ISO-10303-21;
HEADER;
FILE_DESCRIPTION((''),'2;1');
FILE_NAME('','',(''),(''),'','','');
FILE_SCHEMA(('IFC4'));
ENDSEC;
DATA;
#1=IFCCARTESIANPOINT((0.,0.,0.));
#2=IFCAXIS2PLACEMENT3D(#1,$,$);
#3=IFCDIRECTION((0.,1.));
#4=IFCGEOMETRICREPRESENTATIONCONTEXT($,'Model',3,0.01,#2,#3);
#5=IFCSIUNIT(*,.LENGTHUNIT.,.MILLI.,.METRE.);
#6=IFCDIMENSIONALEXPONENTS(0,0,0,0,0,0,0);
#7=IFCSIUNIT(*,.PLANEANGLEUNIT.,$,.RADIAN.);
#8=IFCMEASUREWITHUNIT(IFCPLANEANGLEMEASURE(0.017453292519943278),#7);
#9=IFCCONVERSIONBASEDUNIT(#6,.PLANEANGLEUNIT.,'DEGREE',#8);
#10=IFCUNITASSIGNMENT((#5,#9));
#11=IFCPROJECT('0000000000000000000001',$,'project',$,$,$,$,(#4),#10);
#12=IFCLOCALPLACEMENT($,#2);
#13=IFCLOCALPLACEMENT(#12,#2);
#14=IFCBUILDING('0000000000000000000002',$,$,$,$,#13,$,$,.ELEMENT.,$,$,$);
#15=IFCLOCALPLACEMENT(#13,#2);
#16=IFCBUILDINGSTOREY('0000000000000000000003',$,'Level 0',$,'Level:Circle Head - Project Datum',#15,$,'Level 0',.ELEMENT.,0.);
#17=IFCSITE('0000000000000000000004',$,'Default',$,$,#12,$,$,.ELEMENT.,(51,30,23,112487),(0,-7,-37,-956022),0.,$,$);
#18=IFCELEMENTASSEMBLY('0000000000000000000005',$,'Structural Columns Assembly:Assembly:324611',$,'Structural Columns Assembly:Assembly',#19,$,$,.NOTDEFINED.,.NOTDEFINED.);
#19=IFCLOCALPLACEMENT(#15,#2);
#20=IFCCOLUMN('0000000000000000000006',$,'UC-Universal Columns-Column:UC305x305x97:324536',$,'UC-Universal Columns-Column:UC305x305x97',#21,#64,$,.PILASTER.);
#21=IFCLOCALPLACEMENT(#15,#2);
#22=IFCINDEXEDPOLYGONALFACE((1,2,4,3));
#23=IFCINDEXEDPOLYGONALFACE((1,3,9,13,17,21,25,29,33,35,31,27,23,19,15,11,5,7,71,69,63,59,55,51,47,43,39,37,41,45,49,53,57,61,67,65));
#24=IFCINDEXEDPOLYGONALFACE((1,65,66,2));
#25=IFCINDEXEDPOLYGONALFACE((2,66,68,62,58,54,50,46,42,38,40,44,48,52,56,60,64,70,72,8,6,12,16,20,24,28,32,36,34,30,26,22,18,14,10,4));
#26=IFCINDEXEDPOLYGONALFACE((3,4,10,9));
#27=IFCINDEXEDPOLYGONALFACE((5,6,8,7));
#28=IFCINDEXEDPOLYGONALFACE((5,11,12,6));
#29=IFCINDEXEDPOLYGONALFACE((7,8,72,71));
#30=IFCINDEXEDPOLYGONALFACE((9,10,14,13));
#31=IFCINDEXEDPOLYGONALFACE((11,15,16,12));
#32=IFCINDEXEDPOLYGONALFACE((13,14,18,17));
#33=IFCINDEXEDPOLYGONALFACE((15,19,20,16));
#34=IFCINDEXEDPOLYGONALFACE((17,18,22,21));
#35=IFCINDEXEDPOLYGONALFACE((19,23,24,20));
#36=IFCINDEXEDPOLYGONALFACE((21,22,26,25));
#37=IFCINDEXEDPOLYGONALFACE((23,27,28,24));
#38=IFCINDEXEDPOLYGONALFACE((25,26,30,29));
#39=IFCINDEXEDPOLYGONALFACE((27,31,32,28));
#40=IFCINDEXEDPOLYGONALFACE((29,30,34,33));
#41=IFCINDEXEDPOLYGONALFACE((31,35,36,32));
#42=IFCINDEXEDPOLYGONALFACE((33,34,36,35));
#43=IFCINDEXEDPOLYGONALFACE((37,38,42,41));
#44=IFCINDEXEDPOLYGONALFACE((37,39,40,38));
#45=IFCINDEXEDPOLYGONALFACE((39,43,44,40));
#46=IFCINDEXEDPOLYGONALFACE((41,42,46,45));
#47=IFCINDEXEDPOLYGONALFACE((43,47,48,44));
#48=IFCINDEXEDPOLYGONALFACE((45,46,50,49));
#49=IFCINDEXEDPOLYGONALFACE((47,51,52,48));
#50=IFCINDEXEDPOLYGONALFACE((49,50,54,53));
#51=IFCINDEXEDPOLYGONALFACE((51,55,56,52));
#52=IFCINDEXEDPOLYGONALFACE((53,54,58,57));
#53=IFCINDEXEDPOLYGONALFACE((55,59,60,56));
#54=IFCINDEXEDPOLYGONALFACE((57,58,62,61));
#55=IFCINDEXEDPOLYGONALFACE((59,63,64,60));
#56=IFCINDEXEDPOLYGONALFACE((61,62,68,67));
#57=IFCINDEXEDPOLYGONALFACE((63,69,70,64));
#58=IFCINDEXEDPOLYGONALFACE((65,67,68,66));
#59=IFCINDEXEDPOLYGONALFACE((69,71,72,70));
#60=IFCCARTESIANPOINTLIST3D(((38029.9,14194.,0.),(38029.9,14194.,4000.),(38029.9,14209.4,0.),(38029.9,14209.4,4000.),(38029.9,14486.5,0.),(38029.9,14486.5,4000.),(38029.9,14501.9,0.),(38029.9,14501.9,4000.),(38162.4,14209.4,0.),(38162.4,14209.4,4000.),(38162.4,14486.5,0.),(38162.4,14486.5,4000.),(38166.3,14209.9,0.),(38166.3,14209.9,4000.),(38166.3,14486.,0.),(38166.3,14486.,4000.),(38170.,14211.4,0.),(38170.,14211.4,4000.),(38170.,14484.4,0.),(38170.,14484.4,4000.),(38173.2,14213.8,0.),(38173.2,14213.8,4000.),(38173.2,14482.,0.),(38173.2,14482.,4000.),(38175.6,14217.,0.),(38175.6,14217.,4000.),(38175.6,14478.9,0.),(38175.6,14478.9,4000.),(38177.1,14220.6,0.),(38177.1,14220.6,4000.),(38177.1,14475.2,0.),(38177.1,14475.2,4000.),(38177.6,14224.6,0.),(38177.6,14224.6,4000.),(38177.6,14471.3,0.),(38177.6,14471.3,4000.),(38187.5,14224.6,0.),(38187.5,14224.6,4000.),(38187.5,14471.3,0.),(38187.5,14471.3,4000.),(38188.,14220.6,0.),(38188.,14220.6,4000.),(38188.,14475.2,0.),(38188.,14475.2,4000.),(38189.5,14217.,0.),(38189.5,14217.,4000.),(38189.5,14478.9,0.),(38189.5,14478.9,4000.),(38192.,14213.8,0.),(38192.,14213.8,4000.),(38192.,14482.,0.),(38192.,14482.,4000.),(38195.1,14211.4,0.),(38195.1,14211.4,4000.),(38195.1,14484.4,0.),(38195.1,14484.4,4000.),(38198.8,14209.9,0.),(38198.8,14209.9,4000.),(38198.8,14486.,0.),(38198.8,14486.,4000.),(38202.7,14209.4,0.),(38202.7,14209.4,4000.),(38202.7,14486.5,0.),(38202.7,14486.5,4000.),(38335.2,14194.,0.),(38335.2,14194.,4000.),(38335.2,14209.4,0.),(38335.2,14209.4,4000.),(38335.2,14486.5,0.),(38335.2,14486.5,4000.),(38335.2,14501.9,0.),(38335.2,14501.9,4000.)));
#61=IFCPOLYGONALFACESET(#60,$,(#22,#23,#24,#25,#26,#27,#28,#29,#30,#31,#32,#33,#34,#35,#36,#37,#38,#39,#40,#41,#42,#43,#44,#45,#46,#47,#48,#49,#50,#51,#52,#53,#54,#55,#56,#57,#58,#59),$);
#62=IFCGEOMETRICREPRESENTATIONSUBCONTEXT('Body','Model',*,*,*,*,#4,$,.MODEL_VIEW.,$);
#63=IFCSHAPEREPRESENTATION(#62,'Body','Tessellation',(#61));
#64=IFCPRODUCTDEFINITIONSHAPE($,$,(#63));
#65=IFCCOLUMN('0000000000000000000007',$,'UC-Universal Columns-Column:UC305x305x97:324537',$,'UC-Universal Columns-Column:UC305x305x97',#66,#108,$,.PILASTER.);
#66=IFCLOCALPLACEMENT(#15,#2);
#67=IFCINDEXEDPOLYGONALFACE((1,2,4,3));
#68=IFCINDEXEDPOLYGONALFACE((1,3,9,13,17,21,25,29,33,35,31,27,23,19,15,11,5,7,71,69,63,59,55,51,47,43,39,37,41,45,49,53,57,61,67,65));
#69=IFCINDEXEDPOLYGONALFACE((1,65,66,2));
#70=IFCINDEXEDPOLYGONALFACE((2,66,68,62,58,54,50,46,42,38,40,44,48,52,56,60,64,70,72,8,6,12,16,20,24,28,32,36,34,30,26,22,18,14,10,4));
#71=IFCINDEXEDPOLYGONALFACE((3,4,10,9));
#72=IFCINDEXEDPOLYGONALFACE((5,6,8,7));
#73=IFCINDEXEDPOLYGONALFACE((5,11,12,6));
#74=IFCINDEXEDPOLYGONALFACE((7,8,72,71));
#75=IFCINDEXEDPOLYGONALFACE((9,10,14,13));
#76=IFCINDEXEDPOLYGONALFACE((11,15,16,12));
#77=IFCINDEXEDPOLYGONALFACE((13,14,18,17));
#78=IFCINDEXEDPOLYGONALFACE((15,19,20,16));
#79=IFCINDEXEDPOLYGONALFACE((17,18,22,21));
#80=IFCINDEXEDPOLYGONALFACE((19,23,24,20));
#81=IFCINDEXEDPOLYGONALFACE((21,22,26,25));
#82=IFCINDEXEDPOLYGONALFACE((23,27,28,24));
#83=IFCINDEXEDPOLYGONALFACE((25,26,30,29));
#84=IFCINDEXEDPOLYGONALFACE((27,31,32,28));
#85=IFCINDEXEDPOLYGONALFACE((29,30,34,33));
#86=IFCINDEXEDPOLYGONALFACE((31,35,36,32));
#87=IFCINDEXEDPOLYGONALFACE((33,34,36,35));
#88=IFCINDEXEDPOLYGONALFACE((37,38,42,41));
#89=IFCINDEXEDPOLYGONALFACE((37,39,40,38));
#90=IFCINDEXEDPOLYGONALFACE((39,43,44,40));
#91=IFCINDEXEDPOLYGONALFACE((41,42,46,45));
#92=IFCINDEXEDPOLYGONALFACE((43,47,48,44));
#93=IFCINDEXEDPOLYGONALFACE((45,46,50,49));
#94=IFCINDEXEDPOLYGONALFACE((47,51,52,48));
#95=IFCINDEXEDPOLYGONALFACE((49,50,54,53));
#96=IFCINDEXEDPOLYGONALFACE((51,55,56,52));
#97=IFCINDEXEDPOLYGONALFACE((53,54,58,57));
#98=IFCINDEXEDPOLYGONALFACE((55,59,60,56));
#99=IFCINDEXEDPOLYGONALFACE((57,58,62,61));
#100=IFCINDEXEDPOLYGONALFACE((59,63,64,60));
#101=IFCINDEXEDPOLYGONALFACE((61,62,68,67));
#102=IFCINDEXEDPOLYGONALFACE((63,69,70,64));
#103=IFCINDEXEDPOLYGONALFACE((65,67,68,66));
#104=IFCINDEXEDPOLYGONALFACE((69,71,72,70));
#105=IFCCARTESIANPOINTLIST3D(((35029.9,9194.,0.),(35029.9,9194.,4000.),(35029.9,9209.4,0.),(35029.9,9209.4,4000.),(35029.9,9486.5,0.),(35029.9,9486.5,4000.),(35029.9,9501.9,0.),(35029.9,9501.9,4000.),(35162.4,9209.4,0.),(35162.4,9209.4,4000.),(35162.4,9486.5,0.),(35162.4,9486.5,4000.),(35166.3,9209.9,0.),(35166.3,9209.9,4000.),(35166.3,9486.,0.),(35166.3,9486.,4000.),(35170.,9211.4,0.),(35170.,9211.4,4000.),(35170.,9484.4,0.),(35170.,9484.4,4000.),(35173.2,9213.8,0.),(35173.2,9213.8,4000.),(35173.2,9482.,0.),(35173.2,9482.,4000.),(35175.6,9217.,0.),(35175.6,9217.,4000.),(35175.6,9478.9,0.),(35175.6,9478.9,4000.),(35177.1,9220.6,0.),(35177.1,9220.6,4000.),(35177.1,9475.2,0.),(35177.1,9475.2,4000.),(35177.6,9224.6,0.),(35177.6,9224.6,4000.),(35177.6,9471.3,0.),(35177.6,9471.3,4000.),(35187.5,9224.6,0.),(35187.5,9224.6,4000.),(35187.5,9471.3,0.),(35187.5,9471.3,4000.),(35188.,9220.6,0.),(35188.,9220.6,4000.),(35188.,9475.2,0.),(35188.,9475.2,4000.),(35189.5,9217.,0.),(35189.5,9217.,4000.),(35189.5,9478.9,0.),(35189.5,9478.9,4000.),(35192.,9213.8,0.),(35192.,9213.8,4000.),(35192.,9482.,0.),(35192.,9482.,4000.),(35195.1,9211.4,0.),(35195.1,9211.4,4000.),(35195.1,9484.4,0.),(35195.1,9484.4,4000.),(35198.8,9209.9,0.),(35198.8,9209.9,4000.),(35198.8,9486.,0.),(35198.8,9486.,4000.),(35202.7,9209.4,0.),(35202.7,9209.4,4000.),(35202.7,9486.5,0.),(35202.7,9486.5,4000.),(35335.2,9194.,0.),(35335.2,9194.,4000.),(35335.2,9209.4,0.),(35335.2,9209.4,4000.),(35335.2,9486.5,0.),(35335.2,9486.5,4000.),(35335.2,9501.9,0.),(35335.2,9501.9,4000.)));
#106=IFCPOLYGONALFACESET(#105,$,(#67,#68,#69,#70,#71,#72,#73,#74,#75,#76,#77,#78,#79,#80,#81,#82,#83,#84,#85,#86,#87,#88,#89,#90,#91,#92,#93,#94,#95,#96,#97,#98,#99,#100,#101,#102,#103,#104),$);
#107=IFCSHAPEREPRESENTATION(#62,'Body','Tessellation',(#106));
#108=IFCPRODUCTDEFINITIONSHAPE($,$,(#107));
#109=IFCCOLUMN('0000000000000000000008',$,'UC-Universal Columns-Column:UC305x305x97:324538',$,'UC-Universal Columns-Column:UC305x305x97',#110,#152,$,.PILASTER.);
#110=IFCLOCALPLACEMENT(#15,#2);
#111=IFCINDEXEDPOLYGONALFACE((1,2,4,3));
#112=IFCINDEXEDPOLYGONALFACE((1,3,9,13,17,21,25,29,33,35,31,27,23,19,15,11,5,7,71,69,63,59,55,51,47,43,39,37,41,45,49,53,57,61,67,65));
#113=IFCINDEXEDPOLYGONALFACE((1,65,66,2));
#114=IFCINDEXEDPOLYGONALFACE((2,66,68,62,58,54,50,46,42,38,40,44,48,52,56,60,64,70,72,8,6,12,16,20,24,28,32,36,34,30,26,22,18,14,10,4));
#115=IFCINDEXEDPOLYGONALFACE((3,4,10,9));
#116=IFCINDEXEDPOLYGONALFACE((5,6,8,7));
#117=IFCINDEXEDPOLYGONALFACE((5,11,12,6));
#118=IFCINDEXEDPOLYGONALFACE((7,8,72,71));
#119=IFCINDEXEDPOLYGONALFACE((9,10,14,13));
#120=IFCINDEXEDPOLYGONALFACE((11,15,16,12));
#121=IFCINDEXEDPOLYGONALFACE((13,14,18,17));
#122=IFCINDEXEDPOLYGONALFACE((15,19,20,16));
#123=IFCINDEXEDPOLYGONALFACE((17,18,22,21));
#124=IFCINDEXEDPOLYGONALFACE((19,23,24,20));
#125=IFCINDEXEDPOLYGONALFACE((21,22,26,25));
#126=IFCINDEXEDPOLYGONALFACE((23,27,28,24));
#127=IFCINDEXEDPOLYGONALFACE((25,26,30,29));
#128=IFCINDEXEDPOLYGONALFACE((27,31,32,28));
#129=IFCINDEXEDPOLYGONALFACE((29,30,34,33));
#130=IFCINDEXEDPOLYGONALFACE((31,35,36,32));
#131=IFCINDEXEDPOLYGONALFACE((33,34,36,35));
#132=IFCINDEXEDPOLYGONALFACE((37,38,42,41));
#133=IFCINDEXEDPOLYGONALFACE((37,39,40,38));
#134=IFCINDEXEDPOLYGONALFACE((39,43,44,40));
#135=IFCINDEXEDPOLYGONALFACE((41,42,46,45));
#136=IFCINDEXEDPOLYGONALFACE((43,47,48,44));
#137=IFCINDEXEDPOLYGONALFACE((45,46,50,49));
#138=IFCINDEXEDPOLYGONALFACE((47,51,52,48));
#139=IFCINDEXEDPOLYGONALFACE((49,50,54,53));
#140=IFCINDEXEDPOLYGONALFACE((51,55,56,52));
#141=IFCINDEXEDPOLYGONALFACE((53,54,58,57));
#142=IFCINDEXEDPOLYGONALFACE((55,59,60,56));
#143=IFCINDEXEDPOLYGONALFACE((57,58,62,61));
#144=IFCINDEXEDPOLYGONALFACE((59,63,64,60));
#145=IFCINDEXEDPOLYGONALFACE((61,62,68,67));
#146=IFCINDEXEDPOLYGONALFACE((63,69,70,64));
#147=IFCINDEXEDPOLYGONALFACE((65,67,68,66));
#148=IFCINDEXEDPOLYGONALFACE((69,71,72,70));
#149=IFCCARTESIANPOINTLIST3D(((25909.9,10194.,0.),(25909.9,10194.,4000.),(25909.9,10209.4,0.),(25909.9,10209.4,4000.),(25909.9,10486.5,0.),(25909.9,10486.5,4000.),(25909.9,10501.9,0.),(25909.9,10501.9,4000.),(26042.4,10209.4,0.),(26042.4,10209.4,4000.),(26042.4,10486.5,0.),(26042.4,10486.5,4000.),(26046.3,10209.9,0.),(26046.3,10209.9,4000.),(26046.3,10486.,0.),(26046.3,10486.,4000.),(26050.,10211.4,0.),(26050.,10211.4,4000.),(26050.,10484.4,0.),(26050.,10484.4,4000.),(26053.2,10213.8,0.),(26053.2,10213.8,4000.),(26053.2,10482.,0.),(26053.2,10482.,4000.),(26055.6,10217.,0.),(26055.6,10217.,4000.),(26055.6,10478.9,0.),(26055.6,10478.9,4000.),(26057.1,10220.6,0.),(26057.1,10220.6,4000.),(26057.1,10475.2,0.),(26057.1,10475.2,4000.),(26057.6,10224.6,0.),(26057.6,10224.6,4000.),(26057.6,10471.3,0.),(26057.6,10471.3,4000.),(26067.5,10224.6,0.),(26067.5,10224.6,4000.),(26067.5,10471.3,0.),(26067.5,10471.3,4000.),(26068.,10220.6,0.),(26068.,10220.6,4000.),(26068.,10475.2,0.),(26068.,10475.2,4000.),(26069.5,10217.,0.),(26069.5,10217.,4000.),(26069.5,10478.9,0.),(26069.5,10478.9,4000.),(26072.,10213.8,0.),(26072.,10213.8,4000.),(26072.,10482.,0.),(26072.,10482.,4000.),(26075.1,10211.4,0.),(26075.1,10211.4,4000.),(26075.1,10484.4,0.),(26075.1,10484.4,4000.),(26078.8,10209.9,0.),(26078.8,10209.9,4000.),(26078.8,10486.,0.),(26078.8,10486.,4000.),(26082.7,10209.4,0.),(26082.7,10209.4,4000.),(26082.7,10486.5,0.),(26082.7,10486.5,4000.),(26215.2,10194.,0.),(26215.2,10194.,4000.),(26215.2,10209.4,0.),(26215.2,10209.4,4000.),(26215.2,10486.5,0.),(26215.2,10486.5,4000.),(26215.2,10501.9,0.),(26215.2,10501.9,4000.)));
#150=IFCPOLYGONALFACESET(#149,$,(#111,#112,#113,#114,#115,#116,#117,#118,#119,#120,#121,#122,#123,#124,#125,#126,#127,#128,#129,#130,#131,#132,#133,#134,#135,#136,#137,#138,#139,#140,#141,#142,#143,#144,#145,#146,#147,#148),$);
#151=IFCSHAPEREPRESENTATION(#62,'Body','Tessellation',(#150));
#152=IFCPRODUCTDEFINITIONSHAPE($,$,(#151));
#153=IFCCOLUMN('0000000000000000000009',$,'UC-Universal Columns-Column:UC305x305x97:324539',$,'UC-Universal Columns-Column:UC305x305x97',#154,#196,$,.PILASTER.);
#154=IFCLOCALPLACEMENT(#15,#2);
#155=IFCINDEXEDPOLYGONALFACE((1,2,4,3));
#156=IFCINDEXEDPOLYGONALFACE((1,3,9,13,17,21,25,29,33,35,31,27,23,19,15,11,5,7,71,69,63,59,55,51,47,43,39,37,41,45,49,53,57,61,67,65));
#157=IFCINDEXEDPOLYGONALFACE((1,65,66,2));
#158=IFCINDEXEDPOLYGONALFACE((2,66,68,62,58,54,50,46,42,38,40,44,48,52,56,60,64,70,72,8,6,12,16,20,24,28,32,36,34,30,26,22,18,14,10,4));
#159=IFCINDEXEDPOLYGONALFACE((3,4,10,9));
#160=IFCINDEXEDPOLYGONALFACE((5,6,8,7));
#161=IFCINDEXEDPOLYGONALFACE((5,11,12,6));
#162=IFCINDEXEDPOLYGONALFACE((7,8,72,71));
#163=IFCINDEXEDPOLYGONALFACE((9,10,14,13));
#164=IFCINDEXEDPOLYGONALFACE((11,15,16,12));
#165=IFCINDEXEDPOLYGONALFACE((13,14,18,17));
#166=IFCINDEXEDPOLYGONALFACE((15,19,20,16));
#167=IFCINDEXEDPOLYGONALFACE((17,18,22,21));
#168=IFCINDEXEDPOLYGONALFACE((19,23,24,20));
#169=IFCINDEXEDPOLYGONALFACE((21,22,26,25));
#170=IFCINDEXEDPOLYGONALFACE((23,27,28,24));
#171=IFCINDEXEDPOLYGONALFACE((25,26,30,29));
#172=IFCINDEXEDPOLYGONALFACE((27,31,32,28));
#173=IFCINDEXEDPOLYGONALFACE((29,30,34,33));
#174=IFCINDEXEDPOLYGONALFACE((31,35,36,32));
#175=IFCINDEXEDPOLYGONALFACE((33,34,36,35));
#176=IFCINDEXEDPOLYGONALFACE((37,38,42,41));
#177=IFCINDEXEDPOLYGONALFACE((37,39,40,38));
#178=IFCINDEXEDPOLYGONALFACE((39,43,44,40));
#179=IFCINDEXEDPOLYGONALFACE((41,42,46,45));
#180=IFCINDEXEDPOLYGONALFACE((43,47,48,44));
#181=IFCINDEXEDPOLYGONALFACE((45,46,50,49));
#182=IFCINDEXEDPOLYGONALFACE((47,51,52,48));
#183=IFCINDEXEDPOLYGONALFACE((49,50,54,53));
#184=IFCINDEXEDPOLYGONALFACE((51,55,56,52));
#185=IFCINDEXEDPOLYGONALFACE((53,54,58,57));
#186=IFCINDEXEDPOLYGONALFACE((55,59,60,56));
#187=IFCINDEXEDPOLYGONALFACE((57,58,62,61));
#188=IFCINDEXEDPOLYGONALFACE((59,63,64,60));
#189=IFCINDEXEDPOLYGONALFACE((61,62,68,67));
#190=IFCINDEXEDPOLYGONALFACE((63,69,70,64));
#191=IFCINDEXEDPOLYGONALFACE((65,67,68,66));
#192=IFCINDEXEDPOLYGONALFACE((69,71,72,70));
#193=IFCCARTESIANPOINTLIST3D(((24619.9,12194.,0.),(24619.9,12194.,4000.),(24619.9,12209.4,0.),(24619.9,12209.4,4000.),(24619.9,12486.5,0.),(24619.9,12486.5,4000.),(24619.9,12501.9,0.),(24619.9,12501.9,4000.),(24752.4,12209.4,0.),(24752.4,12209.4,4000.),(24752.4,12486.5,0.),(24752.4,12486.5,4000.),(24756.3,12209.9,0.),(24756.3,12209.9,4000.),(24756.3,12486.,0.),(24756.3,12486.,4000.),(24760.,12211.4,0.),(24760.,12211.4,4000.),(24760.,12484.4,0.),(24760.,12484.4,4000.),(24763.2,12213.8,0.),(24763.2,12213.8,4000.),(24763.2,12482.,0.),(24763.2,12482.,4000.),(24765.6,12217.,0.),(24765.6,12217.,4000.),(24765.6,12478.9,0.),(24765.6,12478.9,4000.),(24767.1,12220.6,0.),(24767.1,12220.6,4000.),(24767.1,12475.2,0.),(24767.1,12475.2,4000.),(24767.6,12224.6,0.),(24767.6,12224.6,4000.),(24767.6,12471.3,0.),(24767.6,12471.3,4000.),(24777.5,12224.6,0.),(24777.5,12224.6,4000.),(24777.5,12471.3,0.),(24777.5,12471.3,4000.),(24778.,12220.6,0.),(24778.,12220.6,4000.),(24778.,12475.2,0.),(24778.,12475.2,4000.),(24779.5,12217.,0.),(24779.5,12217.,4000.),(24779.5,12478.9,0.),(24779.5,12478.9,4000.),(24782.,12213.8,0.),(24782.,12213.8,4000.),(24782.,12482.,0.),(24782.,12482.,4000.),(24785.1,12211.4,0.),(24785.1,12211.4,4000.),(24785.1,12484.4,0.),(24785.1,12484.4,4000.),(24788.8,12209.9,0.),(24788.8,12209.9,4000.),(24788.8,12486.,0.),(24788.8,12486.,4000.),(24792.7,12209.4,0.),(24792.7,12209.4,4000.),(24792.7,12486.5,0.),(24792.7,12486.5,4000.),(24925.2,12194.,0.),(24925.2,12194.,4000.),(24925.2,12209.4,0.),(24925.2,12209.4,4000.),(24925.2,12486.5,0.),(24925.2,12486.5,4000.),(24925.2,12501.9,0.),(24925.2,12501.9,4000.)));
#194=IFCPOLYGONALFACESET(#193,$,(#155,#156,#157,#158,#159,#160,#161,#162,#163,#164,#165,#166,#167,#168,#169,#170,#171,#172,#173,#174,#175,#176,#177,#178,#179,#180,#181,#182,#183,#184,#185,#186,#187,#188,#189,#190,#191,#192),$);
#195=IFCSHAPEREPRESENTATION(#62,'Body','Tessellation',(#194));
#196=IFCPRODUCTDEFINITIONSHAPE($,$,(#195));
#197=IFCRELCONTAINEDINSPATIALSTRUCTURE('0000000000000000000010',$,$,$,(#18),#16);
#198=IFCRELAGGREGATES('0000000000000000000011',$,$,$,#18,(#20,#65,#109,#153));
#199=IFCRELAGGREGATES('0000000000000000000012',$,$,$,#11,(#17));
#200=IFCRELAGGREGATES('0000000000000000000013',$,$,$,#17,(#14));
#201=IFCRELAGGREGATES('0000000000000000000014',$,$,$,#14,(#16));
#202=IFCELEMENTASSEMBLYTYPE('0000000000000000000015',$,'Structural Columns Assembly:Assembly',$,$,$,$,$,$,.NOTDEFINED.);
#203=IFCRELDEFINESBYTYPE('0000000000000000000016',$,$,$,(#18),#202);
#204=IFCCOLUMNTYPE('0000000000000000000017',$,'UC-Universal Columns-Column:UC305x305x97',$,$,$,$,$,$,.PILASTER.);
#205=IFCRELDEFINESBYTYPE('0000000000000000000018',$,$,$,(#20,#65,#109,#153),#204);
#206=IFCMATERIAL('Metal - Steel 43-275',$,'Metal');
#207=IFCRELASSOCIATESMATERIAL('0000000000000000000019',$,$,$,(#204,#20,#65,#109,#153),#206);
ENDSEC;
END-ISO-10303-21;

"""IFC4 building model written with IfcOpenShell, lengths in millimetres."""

from ifc_helpers import new_model, entity, si_unit, converted_unit, direction, frame, origin, place, context, subcontext, project, spatial, line, arc, indexed_curve, outline, extrude, source, transform, mapped, material, type_object, type_shapes, element, aggregate, save


model = new_model("IFC4")

# Units and contexts
model_context = context("Model", 3, precision=0.01, world=origin(), true_north=direction((0.0, 1.0)))
body_context = subcontext(model_context, "Body", "Model", "MODEL_VIEW")
ifc_project = project(units=[si_unit("LENGTHUNIT", "METRE", prefix="MILLI"), converted_unit("PLANEANGLEUNIT", "DEGREE", entity("IfcPlaneAngleMeasure", 0.017453292519943278), si_unit("PLANEANGLEUNIT", "RADIAN"), dimensions=[0, 0, 0, 0, 0, 0, 0])], contexts=[model_context])

# Site, building, storey
site_placement = place(None, origin())
site = spatial("IfcSite", under=ifc_project, at=site_placement, Name="Default", CompositionType="ELEMENT", RefLatitude=(51, 30, 23, 112487), RefLongitude=(0, -7, -37, -956022), RefElevation=0.0)
building_placement = place(site_placement, origin())
building = spatial("IfcBuilding", under=site, at=building_placement, CompositionType="ELEMENT")
storey_placement = place(building_placement, origin())
storey = spatial("IfcBuildingStorey", under=building, at=storey_placement, Name="Level 0", ObjectType="Level:Circle Head - Project Datum", LongName="Level 0", CompositionType="ELEMENT", Elevation=0.0)

# Shared definitions
ifc_material_1 = material(Name="Metal - Steel 43-275", Category="Metal")
column_type = type_object("IfcColumnType", Name="UC-Universal Columns-Column:UC305x305x97", PredefinedType="PILASTER", material=ifc_material_1)
shared_shape_1 = source(origin(), body_context, "Body", "SweptSolid", [
    extrude(outline(indexed_curve([(-152.6, -153.9), (152.6, -153.9), (152.6, -138.5), (20.2, -138.5), (9.4, -134.1), (4.9, -123.4), (4.9, 123.3), (9.4, 134.1), (20.1, 138.5), (152.6, 138.5), (152.6, 153.9), (-152.6, 153.9), (-152.6, 138.5), (-20.2, 138.6), (-9.4, 134.1), (-5.0, 123.4), (-5.0, -123.3), (-9.4, -134.1), (-20.2, -138.5), (-152.6, -138.5)], segments=[line(1, 2, 3, 4), arc(4, 5, 6), line(6, 7), arc(7, 8, 9), line(9, 10, 11, 12, 13, 14), arc(14, 15, 16), line(16, 17), arc(17, 18, 19), line(19, 20, 1)], self_intersect=False)), frame((0.0, 0.0, 0.0), z_axis=(0.0, 0.0, 1.0), x_axis=(-1.0, 0.0, 0.0)), (0.0, 0.0, 1.0), 4000.0),
])
type_shapes(column_type, [shared_shape_1])

# Element assembly, columns
element_assembly_type = type_object("IfcElementAssemblyType", Name="Structural Columns Assembly:Assembly", PredefinedType="NOTDEFINED")
assembly_placement = place(storey_placement, origin())
assembly = element("IfcElementAssembly", 1, at=assembly_placement, inside=storey, type_object=element_assembly_type, Name="Structural Columns Assembly:Assembly:324611", ObjectType="Structural Columns Assembly:Assembly", AssemblyPlace="NOTDEFINED", PredefinedType="NOTDEFINED")
column_1_placement = place(assembly_placement, frame((38182.6, 14347.9, 0.0)))
column_1 = element("IfcColumn", 2, at=column_1_placement, type_object=column_type, material=ifc_material_1, Name="UC-Universal Columns-Column:UC305x305x97:324536", ObjectType="UC-Universal Columns-Column:UC305x305x97", PredefinedType="PILASTER", context=body_context, shape_type="MappedRepresentation", body=[
    mapped(shared_shape_1, transform((0.0, 0.0, 0.0), scale=1.0)),
])
column_2_placement = place(assembly_placement, frame((35182.6, 9347.9, 0.0)))
column_2 = element("IfcColumn", 3, at=column_2_placement, type_object=column_type, material=ifc_material_1, Name="UC-Universal Columns-Column:UC305x305x97:324537", ObjectType="UC-Universal Columns-Column:UC305x305x97", PredefinedType="PILASTER", context=body_context, shape_type="MappedRepresentation", body=[
    mapped(shared_shape_1, transform((0.0, 0.0, 0.0), scale=1.0)),
])
column_3_placement = place(assembly_placement, frame((26062.6, 10347.9, 0.0)))
column_3 = element("IfcColumn", 4, at=column_3_placement, type_object=column_type, material=ifc_material_1, Name="UC-Universal Columns-Column:UC305x305x97:324538", ObjectType="UC-Universal Columns-Column:UC305x305x97", PredefinedType="PILASTER", context=body_context, shape_type="MappedRepresentation", body=[
    mapped(shared_shape_1, transform((0.0, 0.0, 0.0), scale=1.0)),
])
column_4_placement = place(assembly_placement, frame((24772.6, 12347.9, 0.0)))
column_4 = element("IfcColumn", 5, at=column_4_placement, type_object=column_type, material=ifc_material_1, Name="UC-Universal Columns-Column:UC305x305x97:324539", ObjectType="UC-Universal Columns-Column:UC305x305x97", PredefinedType="PILASTER", context=body_context, shape_type="MappedRepresentation", body=[
    mapped(shared_shape_1, transform((0.0, 0.0, 0.0), scale=1.0)),
])
aggregate(assembly, [column_1, column_2, column_3, column_4])

save(model, "model.ifc")
